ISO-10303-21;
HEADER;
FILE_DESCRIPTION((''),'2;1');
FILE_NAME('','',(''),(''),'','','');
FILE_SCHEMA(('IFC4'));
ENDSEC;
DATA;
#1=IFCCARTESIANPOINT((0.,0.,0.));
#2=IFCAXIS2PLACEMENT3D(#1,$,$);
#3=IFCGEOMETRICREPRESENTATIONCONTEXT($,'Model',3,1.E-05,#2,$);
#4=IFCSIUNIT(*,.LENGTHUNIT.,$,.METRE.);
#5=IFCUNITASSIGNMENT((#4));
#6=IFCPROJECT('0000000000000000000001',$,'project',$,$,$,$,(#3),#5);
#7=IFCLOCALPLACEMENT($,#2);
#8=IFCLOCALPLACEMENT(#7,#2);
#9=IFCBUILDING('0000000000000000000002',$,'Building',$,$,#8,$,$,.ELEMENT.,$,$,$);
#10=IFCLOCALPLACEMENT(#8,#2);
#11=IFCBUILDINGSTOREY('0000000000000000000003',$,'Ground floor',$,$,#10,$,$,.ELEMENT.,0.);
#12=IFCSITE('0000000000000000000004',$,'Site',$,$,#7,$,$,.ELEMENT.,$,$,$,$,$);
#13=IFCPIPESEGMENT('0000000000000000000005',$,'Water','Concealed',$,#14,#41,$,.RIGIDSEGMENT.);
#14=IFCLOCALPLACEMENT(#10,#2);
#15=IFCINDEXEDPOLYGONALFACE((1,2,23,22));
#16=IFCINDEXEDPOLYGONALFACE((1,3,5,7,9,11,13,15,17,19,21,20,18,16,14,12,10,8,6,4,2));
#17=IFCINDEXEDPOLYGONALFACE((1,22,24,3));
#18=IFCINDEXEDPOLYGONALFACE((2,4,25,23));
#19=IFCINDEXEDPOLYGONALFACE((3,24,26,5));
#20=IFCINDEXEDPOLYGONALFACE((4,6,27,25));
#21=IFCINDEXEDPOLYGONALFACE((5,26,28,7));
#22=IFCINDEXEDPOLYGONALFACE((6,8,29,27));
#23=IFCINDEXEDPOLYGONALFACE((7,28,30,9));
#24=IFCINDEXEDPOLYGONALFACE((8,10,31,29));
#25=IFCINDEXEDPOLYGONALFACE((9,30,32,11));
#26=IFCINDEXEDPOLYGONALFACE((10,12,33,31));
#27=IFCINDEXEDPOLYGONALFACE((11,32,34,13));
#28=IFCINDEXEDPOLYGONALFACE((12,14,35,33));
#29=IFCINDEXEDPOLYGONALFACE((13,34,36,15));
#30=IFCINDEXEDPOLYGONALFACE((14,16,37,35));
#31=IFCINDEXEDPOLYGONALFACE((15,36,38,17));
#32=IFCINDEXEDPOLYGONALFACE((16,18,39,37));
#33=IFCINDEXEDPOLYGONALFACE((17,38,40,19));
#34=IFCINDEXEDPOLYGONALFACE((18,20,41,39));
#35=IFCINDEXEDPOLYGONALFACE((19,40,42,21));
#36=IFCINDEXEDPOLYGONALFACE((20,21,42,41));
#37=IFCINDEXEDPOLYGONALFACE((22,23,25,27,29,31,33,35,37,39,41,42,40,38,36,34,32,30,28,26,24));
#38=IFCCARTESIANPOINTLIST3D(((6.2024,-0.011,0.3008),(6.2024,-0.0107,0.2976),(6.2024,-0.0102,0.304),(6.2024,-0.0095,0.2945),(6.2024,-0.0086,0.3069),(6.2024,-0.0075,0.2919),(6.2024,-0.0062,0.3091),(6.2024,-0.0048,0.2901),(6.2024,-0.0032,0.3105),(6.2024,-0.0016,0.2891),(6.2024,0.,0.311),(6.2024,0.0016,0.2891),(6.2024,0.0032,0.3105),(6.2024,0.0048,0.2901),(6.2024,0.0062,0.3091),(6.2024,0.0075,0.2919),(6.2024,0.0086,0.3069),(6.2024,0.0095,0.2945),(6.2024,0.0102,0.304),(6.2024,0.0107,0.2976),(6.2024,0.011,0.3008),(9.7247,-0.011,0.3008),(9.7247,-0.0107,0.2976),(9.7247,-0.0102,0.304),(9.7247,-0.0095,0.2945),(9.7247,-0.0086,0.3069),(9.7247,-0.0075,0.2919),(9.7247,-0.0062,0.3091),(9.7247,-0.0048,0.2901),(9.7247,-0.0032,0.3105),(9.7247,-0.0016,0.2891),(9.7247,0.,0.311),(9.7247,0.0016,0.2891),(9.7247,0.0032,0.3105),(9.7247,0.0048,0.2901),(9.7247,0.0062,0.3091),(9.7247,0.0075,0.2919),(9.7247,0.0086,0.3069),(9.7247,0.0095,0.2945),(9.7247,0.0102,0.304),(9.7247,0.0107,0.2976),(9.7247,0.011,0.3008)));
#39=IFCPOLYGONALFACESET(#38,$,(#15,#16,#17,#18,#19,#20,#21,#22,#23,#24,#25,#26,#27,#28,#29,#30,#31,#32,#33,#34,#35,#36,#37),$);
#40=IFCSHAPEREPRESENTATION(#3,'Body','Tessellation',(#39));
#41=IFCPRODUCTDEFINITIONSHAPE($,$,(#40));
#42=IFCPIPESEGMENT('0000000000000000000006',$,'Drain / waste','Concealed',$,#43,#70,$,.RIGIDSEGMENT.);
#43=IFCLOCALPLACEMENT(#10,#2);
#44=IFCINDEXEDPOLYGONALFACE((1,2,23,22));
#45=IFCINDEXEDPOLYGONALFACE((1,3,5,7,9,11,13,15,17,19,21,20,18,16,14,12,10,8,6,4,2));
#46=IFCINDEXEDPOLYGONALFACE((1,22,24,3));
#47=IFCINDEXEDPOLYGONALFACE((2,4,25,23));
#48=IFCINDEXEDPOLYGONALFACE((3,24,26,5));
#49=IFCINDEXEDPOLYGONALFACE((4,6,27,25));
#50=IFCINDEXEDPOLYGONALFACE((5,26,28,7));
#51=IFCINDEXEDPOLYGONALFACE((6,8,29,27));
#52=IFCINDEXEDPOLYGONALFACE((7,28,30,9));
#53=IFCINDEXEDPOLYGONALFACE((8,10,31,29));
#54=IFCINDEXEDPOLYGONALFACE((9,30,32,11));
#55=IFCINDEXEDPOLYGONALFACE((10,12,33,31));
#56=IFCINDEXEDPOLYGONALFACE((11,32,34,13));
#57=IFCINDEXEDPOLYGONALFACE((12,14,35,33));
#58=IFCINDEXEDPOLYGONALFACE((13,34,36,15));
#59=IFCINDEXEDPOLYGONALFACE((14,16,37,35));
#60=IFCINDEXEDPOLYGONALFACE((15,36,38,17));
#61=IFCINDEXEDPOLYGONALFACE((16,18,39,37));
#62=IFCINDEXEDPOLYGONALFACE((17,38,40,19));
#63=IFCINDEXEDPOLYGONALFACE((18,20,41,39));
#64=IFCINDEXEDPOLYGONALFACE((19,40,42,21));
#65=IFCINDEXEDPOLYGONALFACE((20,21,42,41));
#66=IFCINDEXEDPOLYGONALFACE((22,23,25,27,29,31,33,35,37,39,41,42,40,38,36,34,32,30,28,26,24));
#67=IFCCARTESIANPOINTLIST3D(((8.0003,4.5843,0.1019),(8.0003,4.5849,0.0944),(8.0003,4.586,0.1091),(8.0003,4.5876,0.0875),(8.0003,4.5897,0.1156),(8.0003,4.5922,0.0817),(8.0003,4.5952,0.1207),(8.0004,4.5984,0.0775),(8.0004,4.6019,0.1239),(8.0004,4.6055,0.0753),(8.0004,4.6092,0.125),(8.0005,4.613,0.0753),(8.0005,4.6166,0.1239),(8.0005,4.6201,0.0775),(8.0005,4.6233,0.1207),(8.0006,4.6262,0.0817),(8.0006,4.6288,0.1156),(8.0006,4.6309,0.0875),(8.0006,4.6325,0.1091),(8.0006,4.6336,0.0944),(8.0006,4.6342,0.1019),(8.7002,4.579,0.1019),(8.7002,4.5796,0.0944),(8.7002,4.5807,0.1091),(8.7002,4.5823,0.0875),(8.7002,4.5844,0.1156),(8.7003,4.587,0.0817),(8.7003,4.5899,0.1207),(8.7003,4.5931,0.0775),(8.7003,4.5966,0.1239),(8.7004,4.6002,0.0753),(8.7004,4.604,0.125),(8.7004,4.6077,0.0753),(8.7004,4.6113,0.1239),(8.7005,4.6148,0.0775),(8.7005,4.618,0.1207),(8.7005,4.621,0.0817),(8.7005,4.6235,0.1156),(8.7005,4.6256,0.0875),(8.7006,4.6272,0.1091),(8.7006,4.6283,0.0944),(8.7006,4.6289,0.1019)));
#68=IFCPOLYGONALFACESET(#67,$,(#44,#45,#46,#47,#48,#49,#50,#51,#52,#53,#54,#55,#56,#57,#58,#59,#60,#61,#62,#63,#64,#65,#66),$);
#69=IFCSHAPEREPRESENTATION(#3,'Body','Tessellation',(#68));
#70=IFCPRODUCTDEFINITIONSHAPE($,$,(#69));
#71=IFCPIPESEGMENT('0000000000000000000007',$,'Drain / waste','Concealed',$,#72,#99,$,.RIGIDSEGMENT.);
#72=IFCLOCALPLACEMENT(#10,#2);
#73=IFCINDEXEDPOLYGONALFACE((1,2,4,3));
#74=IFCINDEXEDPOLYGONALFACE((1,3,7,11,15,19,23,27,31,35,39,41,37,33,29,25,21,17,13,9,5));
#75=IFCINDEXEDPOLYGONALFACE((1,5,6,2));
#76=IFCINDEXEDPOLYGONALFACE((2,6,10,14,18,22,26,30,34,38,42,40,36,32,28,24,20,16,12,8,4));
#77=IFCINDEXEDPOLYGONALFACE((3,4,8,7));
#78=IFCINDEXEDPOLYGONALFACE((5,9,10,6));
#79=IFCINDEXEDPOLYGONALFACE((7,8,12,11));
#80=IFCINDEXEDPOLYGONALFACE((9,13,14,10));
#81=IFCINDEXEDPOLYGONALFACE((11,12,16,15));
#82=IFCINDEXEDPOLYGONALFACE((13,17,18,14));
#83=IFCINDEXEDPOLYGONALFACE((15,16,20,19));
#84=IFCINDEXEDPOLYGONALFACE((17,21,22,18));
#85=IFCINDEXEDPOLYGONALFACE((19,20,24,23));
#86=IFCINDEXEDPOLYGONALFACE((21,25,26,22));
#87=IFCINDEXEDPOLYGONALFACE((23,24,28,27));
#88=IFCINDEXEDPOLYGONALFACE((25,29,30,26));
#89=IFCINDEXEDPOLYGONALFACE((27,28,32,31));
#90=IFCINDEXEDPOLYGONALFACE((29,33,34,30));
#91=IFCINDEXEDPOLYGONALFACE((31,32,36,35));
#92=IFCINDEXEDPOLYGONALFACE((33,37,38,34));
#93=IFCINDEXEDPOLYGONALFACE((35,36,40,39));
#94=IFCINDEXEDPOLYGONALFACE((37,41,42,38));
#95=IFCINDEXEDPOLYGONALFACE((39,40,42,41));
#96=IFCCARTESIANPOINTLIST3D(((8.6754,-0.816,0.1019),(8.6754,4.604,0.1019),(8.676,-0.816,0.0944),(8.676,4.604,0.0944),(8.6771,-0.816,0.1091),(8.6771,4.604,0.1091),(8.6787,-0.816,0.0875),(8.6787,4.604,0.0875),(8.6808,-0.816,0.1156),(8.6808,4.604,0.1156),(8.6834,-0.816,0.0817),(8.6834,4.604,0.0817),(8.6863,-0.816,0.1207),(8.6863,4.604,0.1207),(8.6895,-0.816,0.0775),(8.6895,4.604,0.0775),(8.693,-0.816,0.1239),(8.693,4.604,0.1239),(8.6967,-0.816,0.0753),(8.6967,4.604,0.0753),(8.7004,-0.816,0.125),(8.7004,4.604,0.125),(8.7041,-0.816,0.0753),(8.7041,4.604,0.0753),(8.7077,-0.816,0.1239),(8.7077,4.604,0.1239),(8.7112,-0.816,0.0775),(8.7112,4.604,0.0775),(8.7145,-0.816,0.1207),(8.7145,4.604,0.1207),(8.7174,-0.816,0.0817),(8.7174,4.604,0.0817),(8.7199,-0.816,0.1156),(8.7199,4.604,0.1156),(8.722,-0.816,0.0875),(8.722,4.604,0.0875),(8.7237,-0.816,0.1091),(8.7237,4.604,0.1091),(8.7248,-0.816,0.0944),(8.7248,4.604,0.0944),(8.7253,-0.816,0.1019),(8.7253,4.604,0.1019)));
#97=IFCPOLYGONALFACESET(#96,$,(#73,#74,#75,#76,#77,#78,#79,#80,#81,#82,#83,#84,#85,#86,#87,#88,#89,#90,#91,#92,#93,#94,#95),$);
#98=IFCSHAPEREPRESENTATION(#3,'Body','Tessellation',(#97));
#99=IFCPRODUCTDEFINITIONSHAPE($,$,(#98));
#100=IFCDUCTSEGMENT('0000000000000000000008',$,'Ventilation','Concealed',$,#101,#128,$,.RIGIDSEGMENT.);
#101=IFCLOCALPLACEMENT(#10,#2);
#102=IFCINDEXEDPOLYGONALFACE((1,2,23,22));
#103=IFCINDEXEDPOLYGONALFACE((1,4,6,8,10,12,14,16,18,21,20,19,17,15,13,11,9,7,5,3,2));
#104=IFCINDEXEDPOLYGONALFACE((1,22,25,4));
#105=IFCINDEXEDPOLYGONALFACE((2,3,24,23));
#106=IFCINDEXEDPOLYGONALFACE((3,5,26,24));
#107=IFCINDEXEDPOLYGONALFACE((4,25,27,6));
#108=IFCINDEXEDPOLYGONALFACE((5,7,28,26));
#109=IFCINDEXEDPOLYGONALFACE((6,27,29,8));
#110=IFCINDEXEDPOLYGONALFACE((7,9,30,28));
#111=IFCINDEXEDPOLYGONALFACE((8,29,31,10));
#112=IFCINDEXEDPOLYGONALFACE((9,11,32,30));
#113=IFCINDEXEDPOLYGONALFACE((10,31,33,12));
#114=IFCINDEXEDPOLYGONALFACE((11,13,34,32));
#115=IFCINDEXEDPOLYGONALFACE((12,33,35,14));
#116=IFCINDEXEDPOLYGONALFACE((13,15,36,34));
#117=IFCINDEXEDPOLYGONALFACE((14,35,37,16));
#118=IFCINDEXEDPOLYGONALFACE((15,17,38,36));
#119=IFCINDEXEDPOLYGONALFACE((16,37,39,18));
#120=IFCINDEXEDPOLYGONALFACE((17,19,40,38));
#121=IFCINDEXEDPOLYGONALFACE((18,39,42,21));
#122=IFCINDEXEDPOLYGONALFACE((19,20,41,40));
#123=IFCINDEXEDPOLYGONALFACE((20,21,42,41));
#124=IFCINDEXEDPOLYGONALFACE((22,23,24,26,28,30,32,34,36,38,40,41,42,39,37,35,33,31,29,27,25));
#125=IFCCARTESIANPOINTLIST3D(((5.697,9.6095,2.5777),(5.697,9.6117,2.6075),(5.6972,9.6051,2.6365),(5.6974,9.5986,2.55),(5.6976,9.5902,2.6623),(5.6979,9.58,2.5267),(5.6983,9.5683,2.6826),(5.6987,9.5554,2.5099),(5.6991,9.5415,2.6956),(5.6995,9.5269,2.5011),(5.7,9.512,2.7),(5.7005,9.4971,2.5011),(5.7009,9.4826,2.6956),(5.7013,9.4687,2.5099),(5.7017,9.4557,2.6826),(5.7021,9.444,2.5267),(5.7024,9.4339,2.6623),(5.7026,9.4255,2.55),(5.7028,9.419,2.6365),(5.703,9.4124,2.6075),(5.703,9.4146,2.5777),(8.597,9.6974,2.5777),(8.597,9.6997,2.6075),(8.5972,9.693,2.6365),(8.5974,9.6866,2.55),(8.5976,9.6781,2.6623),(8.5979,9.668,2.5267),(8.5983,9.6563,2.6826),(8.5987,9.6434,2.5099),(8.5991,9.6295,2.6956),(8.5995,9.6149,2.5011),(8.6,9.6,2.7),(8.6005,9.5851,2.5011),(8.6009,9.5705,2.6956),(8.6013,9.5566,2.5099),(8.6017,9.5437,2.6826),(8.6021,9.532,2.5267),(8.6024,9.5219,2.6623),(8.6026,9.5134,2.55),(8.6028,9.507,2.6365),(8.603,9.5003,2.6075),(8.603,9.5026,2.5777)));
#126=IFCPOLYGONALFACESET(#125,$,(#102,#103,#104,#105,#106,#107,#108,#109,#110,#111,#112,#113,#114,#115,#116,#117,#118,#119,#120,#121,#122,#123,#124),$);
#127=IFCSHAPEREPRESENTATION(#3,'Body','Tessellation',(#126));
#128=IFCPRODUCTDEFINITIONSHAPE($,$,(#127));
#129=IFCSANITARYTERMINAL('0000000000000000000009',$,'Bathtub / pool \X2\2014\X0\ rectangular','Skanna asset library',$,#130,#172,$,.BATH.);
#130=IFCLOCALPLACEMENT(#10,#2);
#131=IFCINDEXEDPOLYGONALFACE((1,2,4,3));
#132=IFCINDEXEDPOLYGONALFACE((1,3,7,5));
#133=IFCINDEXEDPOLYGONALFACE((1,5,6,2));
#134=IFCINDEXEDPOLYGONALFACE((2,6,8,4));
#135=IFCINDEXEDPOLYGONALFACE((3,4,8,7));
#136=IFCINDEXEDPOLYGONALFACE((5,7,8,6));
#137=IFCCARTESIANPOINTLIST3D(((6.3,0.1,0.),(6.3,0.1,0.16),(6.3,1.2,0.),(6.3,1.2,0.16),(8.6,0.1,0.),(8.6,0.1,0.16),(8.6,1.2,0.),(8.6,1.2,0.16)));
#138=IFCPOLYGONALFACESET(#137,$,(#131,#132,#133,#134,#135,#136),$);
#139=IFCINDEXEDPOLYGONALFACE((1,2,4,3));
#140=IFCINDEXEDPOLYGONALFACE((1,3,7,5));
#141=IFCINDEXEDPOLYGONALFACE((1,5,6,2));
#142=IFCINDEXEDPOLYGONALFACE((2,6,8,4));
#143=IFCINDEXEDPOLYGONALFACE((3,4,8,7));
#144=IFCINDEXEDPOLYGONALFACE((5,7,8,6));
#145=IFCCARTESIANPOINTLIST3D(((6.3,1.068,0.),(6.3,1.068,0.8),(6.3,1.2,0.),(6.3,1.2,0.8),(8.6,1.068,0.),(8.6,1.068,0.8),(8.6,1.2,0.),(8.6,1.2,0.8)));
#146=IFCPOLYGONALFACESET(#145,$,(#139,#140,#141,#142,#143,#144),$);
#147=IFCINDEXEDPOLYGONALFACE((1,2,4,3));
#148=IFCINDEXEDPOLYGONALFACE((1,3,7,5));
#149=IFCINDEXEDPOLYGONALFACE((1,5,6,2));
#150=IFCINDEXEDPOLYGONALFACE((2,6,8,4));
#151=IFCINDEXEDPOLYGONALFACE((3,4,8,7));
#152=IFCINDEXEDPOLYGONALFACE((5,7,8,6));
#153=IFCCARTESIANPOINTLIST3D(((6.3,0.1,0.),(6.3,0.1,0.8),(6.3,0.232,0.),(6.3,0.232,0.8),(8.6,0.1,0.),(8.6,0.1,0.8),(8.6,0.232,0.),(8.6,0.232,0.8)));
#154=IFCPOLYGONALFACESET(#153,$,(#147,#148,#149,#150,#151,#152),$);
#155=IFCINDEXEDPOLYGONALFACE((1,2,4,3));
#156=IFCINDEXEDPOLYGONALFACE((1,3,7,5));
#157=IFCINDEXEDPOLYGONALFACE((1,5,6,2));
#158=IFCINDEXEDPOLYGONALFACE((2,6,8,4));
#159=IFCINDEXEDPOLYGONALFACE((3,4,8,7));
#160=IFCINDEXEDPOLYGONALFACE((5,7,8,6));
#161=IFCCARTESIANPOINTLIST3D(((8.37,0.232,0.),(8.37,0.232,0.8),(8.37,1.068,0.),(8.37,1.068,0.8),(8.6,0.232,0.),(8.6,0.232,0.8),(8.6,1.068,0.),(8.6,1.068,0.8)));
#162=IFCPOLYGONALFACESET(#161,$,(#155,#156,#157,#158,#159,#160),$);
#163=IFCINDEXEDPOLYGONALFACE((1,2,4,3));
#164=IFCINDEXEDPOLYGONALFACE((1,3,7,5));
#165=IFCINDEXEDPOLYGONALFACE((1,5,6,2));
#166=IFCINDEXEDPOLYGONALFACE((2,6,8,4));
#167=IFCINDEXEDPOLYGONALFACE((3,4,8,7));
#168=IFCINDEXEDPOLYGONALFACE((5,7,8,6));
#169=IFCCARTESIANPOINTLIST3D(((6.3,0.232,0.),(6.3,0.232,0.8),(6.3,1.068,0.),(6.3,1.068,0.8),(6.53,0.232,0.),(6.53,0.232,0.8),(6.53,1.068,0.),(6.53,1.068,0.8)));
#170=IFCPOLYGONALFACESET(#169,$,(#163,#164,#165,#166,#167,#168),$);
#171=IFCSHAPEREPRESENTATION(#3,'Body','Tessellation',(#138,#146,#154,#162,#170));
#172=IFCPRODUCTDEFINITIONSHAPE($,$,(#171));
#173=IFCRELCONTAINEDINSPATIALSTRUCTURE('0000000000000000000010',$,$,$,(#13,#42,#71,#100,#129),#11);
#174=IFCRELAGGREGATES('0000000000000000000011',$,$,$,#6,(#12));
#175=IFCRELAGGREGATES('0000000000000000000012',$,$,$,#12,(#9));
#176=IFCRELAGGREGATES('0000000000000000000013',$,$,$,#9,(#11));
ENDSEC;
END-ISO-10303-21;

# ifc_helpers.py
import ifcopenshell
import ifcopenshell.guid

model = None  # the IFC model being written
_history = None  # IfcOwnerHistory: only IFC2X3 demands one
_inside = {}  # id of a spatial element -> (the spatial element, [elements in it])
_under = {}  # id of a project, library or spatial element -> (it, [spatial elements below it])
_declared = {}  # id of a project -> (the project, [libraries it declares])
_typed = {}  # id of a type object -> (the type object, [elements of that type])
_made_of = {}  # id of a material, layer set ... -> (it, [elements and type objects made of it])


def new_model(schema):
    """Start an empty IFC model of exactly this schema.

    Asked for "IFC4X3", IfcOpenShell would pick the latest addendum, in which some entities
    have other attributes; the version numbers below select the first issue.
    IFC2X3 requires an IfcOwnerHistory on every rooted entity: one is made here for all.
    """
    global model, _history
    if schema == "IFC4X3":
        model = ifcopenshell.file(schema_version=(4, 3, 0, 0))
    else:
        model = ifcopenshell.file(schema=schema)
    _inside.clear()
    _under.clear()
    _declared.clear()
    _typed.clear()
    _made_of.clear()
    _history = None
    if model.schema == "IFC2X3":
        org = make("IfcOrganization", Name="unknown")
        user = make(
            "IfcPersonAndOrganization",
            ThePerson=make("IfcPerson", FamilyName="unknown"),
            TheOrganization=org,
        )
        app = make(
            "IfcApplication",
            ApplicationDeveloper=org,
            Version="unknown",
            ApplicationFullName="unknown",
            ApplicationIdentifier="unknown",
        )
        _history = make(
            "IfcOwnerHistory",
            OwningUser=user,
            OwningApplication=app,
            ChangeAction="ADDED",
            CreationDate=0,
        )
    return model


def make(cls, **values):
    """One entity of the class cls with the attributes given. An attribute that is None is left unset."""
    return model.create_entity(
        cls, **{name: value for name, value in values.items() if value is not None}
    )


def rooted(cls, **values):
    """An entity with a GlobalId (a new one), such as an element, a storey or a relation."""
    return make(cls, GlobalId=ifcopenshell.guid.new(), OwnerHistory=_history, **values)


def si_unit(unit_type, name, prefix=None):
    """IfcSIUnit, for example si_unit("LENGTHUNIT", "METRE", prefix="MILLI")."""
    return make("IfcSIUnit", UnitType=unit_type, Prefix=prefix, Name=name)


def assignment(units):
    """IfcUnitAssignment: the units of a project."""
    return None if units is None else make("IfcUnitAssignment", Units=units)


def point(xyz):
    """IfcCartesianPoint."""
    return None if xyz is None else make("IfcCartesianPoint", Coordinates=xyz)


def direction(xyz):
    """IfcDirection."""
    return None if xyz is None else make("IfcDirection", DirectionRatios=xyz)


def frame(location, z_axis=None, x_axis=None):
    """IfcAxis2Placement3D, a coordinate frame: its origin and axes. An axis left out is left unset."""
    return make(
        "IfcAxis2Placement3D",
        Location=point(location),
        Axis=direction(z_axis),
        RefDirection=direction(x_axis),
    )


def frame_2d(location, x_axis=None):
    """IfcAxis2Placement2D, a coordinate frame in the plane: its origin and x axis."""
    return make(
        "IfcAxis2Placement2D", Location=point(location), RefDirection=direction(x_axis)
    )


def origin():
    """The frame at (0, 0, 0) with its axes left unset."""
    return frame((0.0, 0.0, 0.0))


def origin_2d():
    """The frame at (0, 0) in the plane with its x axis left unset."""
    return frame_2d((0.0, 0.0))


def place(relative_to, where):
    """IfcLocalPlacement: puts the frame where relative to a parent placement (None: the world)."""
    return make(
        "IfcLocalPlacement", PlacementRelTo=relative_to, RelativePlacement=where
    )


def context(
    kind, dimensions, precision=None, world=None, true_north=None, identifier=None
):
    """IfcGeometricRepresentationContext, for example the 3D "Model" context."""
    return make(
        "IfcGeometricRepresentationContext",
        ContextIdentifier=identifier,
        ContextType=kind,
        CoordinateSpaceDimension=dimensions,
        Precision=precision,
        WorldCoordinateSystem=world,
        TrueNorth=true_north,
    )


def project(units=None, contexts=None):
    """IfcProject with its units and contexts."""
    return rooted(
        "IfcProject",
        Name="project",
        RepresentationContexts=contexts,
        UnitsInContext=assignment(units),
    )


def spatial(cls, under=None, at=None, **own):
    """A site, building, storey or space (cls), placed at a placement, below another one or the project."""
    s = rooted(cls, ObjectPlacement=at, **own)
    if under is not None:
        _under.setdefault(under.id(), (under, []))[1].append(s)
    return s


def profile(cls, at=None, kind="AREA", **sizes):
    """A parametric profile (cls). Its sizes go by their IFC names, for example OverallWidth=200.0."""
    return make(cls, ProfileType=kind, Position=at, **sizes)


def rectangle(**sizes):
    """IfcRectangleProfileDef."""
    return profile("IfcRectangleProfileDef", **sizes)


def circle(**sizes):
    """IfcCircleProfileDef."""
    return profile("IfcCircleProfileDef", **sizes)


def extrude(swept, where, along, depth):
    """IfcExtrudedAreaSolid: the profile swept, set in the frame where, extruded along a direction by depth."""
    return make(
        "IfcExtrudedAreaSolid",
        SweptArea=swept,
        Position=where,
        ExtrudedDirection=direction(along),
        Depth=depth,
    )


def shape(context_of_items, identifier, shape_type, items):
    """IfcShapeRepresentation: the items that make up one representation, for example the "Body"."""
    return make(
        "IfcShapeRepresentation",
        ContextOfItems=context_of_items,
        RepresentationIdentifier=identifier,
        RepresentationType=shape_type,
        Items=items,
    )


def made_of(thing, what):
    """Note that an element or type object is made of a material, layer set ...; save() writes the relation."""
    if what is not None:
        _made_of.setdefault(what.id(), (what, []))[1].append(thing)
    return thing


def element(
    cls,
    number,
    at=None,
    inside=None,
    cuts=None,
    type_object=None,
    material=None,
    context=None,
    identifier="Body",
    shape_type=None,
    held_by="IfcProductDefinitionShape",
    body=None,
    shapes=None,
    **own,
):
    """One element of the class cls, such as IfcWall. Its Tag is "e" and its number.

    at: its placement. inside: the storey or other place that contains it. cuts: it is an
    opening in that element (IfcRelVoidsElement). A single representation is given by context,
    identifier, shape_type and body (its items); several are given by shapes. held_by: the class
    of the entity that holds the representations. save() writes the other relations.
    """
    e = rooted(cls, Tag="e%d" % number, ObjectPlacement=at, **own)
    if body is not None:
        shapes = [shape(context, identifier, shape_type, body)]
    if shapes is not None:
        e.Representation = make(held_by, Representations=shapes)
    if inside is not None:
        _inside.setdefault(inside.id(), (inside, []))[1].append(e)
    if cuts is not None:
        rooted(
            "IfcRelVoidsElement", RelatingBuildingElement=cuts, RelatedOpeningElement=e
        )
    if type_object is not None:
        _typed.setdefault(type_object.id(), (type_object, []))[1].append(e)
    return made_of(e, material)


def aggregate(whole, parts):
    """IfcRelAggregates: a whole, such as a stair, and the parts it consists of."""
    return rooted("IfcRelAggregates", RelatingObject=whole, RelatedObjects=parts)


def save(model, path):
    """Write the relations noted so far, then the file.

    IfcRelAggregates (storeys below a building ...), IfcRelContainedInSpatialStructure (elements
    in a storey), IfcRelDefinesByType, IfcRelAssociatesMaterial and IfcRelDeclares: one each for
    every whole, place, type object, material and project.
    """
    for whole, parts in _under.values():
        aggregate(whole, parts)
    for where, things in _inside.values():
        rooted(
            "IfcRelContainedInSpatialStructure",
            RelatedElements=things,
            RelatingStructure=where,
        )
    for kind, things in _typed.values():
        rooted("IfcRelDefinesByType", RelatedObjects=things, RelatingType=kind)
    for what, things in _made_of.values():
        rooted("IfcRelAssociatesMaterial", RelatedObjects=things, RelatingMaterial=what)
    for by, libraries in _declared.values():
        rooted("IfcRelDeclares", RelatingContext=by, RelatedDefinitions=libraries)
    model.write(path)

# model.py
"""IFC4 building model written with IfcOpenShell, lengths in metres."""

from ifc_helpers import new_model, si_unit, frame, frame_2d, origin, origin_2d, place, context, project, spatial, rectangle, circle, extrude, element, save


model = new_model("IFC4")

# Units and contexts
model_context = context("Model", 3, precision=1e-05, world=origin())
ifc_project = project(units=[si_unit("LENGTHUNIT", "METRE")], contexts=[model_context])

# Site, building, storey
site_placement = place(None, origin())
site = spatial("IfcSite", under=ifc_project, at=site_placement, Name="Site", CompositionType="ELEMENT")
building_placement = place(site_placement, origin())
building = spatial("IfcBuilding", under=site, at=building_placement, Name="Building", CompositionType="ELEMENT")
storey_placement = place(building_placement, origin())
storey = spatial("IfcBuildingStorey", under=building, at=storey_placement, Name="Ground floor", CompositionType="ELEMENT", Elevation=0.0)

# Pipe segments
pipe_segment_1_placement = place(storey_placement, frame((9.7247, 0.0, 0.3), z_axis=(-1.0, 0.0, 0.0), x_axis=(0.0, 0.0, 1.0)))
element("IfcPipeSegment", 1, at=pipe_segment_1_placement, inside=storey, Name="Water", Description="Concealed", PredefinedType="RIGIDSEGMENT", context=model_context, shape_type="SweptSolid", body=[
    extrude(circle(Radius=0.011, at=origin_2d()), origin(), (0.0, 0.0, 1.0), 3.5224),
])
pipe_segment_2_placement = place(storey_placement, frame((8.0004, 4.6092, 0.1), z_axis=(0.999972, -0.007547, 0.0), x_axis=(0.0, 0.0, 1.0)))
element("IfcPipeSegment", 2, at=pipe_segment_2_placement, inside=storey, Name="Drain / waste", Description="Concealed", PredefinedType="RIGIDSEGMENT", context=model_context, shape_type="SweptSolid", body=[
    extrude(circle(Radius=0.025, at=origin_2d()), origin(), (0.0, 0.0, 1.0), 0.7),
])
pipe_segment_3_placement = place(storey_placement, frame((8.7004, 4.604, 0.1), z_axis=(0.0, -1.0, 0.0), x_axis=(0.0, 0.0, 1.0)))
element("IfcPipeSegment", 3, at=pipe_segment_3_placement, inside=storey, Name="Drain / waste", Description="Concealed", PredefinedType="RIGIDSEGMENT", context=model_context, shape_type="SweptSolid", body=[
    extrude(circle(Radius=0.025, at=origin_2d()), origin(), (0.0, 0.0, 1.0), 5.42),
])

# Duct segment
duct_segment_placement = place(storey_placement, frame((8.6, 9.6, 2.6), z_axis=(-0.99954, -0.030322, 0.0), x_axis=(0.0, 0.0, 1.0)))
element("IfcDuctSegment", 4, at=duct_segment_placement, inside=storey, Name="Ventilation", Description="Concealed", PredefinedType="RIGIDSEGMENT", context=model_context, shape_type="SweptSolid", body=[
    extrude(circle(Radius=0.1, at=origin_2d()), origin(), (0.0, 0.0, 1.0), 2.9013),
])

# Sanitary terminal
sanitary_terminal_1_placement = place(storey_placement, frame((7.45, 0.65, 0.0), z_axis=(0.0, 0.0, 1.0), x_axis=(-1.0, 0.0, 0.0)))
element("IfcSanitaryTerminal", 5, at=sanitary_terminal_1_placement, inside=storey, Name="Bathtub / pool — rectangular", Description="Skanna asset library", PredefinedType="BATH", context=model_context, shape_type="SweptSolid", body=[
    extrude(rectangle(XDim=2.3, YDim=1.1, at=origin_2d()), origin(), (0.0, 0.0, 1.0), 0.16),
    extrude(rectangle(XDim=2.3, YDim=0.132, at=frame_2d((0.0, -0.484))), origin(), (0.0, 0.0, 1.0), 0.8),
    extrude(rectangle(XDim=2.3, YDim=0.132, at=frame_2d((0.0, 0.484))), origin(), (0.0, 0.0, 1.0), 0.8),
    extrude(rectangle(XDim=0.23, YDim=0.836, at=frame_2d((-1.035, 0.0))), origin(), (0.0, 0.0, 1.0), 0.8),
    extrude(rectangle(XDim=0.23, YDim=0.836, at=frame_2d((1.035, 0.0))), origin(), (0.0, 0.0, 1.0), 0.8),
])

save(model, "model.ifc")
